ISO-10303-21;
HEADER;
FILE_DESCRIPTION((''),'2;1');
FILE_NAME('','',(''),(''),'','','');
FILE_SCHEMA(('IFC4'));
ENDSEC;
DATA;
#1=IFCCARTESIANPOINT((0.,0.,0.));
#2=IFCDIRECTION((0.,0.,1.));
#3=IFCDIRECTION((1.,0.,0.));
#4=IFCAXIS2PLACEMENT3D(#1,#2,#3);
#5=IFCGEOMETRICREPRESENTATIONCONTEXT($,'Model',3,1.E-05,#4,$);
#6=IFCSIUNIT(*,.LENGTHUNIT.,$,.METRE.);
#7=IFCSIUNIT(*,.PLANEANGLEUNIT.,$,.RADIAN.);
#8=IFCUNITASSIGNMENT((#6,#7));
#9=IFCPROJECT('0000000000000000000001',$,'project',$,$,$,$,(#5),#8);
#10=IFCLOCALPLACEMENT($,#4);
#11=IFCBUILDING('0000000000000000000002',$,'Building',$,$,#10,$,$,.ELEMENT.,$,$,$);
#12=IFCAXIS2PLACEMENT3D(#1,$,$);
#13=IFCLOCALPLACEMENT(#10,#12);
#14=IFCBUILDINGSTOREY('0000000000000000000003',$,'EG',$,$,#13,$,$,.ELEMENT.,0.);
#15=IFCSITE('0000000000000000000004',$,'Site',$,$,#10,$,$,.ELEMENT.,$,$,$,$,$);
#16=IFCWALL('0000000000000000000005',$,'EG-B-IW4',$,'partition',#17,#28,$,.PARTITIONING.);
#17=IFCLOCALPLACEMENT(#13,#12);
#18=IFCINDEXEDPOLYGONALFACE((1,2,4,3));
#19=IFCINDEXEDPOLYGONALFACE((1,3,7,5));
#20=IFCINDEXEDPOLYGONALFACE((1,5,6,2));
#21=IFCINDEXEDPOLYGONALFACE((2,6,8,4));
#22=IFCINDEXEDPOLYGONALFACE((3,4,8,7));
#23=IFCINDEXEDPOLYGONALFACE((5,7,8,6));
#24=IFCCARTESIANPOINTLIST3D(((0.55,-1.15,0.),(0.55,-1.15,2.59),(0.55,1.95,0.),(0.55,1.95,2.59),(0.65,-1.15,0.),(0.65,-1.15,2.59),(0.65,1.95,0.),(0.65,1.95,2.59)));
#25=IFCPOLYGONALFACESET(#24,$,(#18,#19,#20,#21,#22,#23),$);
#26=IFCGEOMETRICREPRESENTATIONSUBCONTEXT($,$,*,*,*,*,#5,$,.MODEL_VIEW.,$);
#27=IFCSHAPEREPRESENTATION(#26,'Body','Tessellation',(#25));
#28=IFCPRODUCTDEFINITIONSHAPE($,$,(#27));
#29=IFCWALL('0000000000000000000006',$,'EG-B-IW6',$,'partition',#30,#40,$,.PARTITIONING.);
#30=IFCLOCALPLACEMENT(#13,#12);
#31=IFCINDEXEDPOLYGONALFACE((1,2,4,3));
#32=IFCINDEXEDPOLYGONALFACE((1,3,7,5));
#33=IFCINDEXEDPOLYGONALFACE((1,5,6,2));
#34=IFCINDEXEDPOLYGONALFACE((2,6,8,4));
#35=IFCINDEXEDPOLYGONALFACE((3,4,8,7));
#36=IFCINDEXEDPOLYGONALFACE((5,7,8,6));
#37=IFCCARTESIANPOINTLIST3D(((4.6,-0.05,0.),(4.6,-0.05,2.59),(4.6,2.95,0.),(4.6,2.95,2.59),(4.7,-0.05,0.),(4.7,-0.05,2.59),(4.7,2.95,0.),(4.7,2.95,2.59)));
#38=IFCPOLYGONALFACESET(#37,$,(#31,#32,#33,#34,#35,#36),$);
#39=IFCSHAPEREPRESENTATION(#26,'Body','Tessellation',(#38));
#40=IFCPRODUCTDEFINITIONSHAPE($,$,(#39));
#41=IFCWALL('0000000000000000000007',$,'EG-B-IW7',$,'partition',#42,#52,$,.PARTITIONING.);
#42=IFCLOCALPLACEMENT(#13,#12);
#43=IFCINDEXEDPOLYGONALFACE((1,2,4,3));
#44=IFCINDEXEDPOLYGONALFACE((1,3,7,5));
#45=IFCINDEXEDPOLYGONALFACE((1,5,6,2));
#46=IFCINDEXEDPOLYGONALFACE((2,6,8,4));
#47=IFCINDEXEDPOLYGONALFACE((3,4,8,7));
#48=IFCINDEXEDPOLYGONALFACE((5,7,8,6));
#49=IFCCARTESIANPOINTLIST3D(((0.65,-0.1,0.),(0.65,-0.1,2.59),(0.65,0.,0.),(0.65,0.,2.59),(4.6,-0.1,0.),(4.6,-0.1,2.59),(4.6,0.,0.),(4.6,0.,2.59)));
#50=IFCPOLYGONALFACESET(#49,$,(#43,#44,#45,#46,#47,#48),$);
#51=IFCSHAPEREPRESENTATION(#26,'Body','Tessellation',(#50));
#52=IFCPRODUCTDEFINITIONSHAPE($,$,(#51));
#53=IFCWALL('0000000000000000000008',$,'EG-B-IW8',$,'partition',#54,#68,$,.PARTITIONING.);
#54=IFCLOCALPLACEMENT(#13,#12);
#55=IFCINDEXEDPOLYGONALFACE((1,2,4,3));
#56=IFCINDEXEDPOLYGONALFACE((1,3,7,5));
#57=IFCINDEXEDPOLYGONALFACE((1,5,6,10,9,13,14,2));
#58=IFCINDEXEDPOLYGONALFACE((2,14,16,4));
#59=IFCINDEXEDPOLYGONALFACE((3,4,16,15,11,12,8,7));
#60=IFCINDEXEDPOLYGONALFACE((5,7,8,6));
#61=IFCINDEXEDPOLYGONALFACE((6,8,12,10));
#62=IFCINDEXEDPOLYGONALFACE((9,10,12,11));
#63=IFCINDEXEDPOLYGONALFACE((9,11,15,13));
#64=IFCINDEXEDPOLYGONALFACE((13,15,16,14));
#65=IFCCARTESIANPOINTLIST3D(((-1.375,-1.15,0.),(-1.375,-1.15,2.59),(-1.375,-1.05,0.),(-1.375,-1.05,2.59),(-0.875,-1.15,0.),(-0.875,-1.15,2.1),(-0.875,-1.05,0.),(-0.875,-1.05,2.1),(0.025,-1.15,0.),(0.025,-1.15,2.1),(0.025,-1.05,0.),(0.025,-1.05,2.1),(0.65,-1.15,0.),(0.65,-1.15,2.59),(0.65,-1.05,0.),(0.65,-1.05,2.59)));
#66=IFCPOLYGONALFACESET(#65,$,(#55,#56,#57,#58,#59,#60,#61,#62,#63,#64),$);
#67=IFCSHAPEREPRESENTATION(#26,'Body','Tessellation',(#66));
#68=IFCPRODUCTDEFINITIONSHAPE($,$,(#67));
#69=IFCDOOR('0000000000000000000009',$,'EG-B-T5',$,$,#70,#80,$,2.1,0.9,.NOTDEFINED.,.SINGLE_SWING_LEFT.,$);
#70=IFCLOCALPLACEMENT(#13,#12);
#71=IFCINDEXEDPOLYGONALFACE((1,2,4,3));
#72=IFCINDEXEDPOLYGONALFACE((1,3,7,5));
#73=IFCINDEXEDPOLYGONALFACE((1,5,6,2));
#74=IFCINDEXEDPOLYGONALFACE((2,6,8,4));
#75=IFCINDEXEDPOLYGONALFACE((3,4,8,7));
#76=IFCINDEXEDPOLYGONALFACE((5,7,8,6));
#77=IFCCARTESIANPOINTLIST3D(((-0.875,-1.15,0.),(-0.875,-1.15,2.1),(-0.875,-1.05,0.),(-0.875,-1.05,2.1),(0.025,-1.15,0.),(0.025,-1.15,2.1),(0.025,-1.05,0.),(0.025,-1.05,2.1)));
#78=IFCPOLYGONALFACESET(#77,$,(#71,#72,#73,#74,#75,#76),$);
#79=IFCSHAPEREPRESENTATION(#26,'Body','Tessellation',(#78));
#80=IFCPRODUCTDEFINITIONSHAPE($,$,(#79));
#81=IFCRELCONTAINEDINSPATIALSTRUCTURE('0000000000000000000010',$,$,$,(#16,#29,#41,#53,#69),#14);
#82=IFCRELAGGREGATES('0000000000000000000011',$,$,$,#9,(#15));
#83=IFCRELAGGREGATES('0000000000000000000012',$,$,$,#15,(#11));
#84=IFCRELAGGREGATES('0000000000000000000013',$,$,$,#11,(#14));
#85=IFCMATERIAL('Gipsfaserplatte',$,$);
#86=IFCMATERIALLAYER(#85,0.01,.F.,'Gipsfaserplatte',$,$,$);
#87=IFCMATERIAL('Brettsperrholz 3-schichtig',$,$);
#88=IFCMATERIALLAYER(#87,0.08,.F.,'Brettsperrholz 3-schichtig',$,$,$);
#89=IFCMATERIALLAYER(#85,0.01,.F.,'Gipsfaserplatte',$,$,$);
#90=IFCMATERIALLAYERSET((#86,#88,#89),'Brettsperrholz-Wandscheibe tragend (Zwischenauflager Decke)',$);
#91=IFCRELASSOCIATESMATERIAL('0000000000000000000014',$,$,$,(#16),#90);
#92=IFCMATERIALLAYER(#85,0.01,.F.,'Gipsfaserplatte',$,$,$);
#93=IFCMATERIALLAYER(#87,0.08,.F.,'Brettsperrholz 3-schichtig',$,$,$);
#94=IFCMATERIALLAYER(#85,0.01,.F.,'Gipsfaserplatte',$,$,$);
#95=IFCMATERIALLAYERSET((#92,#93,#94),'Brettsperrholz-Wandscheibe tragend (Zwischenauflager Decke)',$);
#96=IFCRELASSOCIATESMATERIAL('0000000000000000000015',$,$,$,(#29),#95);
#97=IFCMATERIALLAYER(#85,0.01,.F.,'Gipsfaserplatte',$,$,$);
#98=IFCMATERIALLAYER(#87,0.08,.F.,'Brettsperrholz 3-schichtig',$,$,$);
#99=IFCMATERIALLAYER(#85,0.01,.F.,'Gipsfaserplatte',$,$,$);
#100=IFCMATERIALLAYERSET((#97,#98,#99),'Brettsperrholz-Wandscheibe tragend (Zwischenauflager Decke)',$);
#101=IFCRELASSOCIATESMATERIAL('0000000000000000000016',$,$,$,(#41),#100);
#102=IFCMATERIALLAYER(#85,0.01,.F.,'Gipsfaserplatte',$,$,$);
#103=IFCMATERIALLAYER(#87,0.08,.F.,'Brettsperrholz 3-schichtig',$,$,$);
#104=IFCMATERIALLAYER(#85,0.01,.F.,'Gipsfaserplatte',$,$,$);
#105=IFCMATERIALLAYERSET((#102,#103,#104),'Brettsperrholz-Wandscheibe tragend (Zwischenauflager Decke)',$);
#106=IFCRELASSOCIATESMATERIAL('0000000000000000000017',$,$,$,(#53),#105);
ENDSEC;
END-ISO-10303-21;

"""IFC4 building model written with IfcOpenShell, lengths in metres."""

from ifc_helpers import new_model, si_unit, frame, frame_2d, origin, origin_with_axes, place, context, subcontext, project, spatial, rectangle, extrude, material, layer, layer_set, element, fill, save


model = new_model("IFC4")

# Units and contexts
model_context = context("Model", 3, precision=1e-05, world=origin_with_axes())
sub_context = subcontext(model_context, None, None, "MODEL_VIEW")
ifc_project = project(units=[si_unit("LENGTHUNIT", "METRE"), si_unit("PLANEANGLEUNIT", "RADIAN")], contexts=[model_context])

# Site, building, storey
placement = place(None, origin_with_axes())
site = spatial("IfcSite", under=ifc_project, at=placement, Name="Site", CompositionType="ELEMENT")
building = spatial("IfcBuilding", under=site, at=placement, Name="Building", CompositionType="ELEMENT")
storey_placement = place(placement, origin())
storey = spatial("IfcBuildingStorey", under=building, at=storey_placement, Name="EG", CompositionType="ELEMENT", Elevation=0.0)

# Shared definitions
ifc_material_1 = material(Name="Gipsfaserplatte")

# Walls
ifc_layer_1 = layer(ifc_material_1, 0.01, ventilated=False, Name="Gipsfaserplatte")
ifc_material_2 = material(Name="Brettsperrholz 3-schichtig")
ifc_layer_2 = layer(ifc_material_2, 0.08, ventilated=False, Name="Brettsperrholz 3-schichtig")
ifc_layer_3 = layer(ifc_material_1, 0.01, ventilated=False, Name="Gipsfaserplatte")
ifc_layer_set_1 = layer_set([ifc_layer_1, ifc_layer_2, ifc_layer_3], Name="Brettsperrholz-Wandscheibe tragend (Zwischenauflager Decke)")
wall_1_placement = place(storey_placement, frame((0.6, -1.15, 0.0), z_axis=(0.0, 0.0, 1.0), x_axis=(0.0, 1.0, 0.0)))
element("IfcWall", 1, at=wall_1_placement, inside=storey, material=ifc_layer_set_1, Name="EG-B-IW4", ObjectType="partition", PredefinedType="PARTITIONING", context=sub_context, shape_type="SweptSolid", body=[
    extrude(rectangle(XDim=3.1, YDim=0.1, at=frame_2d((1.55, 0.0))), origin(), (0.0, 0.0, 1.0), 2.59),
])
ifc_layer_4 = layer(ifc_material_1, 0.01, ventilated=False, Name="Gipsfaserplatte")
ifc_layer_5 = layer(ifc_material_2, 0.08, ventilated=False, Name="Brettsperrholz 3-schichtig")
ifc_layer_6 = layer(ifc_material_1, 0.01, ventilated=False, Name="Gipsfaserplatte")
ifc_layer_set_2 = layer_set([ifc_layer_4, ifc_layer_5, ifc_layer_6], Name="Brettsperrholz-Wandscheibe tragend (Zwischenauflager Decke)")
wall_2_placement = place(storey_placement, frame((4.65, -0.05, 0.0), z_axis=(0.0, 0.0, 1.0), x_axis=(0.0, 1.0, 0.0)))
element("IfcWall", 2, at=wall_2_placement, inside=storey, material=ifc_layer_set_2, Name="EG-B-IW6", ObjectType="partition", PredefinedType="PARTITIONING", context=sub_context, shape_type="SweptSolid", body=[
    extrude(rectangle(XDim=3.0, YDim=0.1, at=frame_2d((1.5, 0.0))), origin(), (0.0, 0.0, 1.0), 2.59),
])
ifc_layer_7 = layer(ifc_material_1, 0.01, ventilated=False, Name="Gipsfaserplatte")
ifc_layer_8 = layer(ifc_material_2, 0.08, ventilated=False, Name="Brettsperrholz 3-schichtig")
ifc_layer_9 = layer(ifc_material_1, 0.01, ventilated=False, Name="Gipsfaserplatte")
ifc_layer_set_3 = layer_set([ifc_layer_7, ifc_layer_8, ifc_layer_9], Name="Brettsperrholz-Wandscheibe tragend (Zwischenauflager Decke)")
wall_3_placement = place(storey_placement, frame((0.65, -0.05, 0.0), z_axis=(0.0, 0.0, 1.0), x_axis=(1.0, 0.0, 0.0)))
element("IfcWall", 3, at=wall_3_placement, inside=storey, material=ifc_layer_set_3, Name="EG-B-IW7", ObjectType="partition", PredefinedType="PARTITIONING", context=sub_context, shape_type="SweptSolid", body=[
    extrude(rectangle(XDim=3.95, YDim=0.1, at=frame_2d((1.975, 0.0))), origin(), (0.0, 0.0, 1.0), 2.59),
])

# Wall, opening, door
ifc_layer_10 = layer(ifc_material_1, 0.01, ventilated=False, Name="Gipsfaserplatte")
ifc_layer_11 = layer(ifc_material_2, 0.08, ventilated=False, Name="Brettsperrholz 3-schichtig")
ifc_layer_12 = layer(ifc_material_1, 0.01, ventilated=False, Name="Gipsfaserplatte")
ifc_layer_set_4 = layer_set([ifc_layer_10, ifc_layer_11, ifc_layer_12], Name="Brettsperrholz-Wandscheibe tragend (Zwischenauflager Decke)")
wall_4_placement = place(storey_placement, frame((-1.375, -1.1, 0.0), z_axis=(0.0, 0.0, 1.0), x_axis=(1.0, 0.0, 0.0)))
wall_4 = element("IfcWall", 4, at=wall_4_placement, inside=storey, material=ifc_layer_set_4, Name="EG-B-IW8", ObjectType="partition", PredefinedType="PARTITIONING", context=sub_context, shape_type="SweptSolid", body=[
    extrude(rectangle(XDim=2.025, YDim=0.1, at=frame_2d((1.0125, 0.0))), origin(), (0.0, 0.0, 1.0), 2.59),
])
opening_1_placement = place(wall_4_placement, frame((0.95, 0.1, 0.0), z_axis=(0.0, -1.0, 0.0), x_axis=(1.0, 0.0, 0.0)))
opening_1 = element("IfcOpeningElement", 5, at=opening_1_placement, cuts=wall_4, PredefinedType="OPENING", context=sub_context, shape_type="SweptSolid", body=[
    extrude(rectangle(XDim=0.9, YDim=2.1, at=frame_2d((0.0, 1.05))), origin(), (0.0, 0.0, 1.0), 0.2),
])
door_1_placement = place(wall_4_placement, frame((0.95, 0.05, 0.0), z_axis=(0.0, -1.0, 0.0), x_axis=(1.0, 0.0, 0.0)))
door_1 = element("IfcDoor", 6, at=door_1_placement, inside=storey, Name="EG-B-T5", OperationType="SINGLE_SWING_LEFT", OverallHeight=2.1, OverallWidth=0.9, PredefinedType="NOTDEFINED", context=sub_context, shape_type="SweptSolid", body=[
    extrude(rectangle(XDim=0.9, YDim=2.1, at=frame_2d((0.0, 1.05))), origin(), (0.0, 0.0, 1.0), 0.1),
])
fill(opening_1, door_1)

save(model, "model.ifc")
